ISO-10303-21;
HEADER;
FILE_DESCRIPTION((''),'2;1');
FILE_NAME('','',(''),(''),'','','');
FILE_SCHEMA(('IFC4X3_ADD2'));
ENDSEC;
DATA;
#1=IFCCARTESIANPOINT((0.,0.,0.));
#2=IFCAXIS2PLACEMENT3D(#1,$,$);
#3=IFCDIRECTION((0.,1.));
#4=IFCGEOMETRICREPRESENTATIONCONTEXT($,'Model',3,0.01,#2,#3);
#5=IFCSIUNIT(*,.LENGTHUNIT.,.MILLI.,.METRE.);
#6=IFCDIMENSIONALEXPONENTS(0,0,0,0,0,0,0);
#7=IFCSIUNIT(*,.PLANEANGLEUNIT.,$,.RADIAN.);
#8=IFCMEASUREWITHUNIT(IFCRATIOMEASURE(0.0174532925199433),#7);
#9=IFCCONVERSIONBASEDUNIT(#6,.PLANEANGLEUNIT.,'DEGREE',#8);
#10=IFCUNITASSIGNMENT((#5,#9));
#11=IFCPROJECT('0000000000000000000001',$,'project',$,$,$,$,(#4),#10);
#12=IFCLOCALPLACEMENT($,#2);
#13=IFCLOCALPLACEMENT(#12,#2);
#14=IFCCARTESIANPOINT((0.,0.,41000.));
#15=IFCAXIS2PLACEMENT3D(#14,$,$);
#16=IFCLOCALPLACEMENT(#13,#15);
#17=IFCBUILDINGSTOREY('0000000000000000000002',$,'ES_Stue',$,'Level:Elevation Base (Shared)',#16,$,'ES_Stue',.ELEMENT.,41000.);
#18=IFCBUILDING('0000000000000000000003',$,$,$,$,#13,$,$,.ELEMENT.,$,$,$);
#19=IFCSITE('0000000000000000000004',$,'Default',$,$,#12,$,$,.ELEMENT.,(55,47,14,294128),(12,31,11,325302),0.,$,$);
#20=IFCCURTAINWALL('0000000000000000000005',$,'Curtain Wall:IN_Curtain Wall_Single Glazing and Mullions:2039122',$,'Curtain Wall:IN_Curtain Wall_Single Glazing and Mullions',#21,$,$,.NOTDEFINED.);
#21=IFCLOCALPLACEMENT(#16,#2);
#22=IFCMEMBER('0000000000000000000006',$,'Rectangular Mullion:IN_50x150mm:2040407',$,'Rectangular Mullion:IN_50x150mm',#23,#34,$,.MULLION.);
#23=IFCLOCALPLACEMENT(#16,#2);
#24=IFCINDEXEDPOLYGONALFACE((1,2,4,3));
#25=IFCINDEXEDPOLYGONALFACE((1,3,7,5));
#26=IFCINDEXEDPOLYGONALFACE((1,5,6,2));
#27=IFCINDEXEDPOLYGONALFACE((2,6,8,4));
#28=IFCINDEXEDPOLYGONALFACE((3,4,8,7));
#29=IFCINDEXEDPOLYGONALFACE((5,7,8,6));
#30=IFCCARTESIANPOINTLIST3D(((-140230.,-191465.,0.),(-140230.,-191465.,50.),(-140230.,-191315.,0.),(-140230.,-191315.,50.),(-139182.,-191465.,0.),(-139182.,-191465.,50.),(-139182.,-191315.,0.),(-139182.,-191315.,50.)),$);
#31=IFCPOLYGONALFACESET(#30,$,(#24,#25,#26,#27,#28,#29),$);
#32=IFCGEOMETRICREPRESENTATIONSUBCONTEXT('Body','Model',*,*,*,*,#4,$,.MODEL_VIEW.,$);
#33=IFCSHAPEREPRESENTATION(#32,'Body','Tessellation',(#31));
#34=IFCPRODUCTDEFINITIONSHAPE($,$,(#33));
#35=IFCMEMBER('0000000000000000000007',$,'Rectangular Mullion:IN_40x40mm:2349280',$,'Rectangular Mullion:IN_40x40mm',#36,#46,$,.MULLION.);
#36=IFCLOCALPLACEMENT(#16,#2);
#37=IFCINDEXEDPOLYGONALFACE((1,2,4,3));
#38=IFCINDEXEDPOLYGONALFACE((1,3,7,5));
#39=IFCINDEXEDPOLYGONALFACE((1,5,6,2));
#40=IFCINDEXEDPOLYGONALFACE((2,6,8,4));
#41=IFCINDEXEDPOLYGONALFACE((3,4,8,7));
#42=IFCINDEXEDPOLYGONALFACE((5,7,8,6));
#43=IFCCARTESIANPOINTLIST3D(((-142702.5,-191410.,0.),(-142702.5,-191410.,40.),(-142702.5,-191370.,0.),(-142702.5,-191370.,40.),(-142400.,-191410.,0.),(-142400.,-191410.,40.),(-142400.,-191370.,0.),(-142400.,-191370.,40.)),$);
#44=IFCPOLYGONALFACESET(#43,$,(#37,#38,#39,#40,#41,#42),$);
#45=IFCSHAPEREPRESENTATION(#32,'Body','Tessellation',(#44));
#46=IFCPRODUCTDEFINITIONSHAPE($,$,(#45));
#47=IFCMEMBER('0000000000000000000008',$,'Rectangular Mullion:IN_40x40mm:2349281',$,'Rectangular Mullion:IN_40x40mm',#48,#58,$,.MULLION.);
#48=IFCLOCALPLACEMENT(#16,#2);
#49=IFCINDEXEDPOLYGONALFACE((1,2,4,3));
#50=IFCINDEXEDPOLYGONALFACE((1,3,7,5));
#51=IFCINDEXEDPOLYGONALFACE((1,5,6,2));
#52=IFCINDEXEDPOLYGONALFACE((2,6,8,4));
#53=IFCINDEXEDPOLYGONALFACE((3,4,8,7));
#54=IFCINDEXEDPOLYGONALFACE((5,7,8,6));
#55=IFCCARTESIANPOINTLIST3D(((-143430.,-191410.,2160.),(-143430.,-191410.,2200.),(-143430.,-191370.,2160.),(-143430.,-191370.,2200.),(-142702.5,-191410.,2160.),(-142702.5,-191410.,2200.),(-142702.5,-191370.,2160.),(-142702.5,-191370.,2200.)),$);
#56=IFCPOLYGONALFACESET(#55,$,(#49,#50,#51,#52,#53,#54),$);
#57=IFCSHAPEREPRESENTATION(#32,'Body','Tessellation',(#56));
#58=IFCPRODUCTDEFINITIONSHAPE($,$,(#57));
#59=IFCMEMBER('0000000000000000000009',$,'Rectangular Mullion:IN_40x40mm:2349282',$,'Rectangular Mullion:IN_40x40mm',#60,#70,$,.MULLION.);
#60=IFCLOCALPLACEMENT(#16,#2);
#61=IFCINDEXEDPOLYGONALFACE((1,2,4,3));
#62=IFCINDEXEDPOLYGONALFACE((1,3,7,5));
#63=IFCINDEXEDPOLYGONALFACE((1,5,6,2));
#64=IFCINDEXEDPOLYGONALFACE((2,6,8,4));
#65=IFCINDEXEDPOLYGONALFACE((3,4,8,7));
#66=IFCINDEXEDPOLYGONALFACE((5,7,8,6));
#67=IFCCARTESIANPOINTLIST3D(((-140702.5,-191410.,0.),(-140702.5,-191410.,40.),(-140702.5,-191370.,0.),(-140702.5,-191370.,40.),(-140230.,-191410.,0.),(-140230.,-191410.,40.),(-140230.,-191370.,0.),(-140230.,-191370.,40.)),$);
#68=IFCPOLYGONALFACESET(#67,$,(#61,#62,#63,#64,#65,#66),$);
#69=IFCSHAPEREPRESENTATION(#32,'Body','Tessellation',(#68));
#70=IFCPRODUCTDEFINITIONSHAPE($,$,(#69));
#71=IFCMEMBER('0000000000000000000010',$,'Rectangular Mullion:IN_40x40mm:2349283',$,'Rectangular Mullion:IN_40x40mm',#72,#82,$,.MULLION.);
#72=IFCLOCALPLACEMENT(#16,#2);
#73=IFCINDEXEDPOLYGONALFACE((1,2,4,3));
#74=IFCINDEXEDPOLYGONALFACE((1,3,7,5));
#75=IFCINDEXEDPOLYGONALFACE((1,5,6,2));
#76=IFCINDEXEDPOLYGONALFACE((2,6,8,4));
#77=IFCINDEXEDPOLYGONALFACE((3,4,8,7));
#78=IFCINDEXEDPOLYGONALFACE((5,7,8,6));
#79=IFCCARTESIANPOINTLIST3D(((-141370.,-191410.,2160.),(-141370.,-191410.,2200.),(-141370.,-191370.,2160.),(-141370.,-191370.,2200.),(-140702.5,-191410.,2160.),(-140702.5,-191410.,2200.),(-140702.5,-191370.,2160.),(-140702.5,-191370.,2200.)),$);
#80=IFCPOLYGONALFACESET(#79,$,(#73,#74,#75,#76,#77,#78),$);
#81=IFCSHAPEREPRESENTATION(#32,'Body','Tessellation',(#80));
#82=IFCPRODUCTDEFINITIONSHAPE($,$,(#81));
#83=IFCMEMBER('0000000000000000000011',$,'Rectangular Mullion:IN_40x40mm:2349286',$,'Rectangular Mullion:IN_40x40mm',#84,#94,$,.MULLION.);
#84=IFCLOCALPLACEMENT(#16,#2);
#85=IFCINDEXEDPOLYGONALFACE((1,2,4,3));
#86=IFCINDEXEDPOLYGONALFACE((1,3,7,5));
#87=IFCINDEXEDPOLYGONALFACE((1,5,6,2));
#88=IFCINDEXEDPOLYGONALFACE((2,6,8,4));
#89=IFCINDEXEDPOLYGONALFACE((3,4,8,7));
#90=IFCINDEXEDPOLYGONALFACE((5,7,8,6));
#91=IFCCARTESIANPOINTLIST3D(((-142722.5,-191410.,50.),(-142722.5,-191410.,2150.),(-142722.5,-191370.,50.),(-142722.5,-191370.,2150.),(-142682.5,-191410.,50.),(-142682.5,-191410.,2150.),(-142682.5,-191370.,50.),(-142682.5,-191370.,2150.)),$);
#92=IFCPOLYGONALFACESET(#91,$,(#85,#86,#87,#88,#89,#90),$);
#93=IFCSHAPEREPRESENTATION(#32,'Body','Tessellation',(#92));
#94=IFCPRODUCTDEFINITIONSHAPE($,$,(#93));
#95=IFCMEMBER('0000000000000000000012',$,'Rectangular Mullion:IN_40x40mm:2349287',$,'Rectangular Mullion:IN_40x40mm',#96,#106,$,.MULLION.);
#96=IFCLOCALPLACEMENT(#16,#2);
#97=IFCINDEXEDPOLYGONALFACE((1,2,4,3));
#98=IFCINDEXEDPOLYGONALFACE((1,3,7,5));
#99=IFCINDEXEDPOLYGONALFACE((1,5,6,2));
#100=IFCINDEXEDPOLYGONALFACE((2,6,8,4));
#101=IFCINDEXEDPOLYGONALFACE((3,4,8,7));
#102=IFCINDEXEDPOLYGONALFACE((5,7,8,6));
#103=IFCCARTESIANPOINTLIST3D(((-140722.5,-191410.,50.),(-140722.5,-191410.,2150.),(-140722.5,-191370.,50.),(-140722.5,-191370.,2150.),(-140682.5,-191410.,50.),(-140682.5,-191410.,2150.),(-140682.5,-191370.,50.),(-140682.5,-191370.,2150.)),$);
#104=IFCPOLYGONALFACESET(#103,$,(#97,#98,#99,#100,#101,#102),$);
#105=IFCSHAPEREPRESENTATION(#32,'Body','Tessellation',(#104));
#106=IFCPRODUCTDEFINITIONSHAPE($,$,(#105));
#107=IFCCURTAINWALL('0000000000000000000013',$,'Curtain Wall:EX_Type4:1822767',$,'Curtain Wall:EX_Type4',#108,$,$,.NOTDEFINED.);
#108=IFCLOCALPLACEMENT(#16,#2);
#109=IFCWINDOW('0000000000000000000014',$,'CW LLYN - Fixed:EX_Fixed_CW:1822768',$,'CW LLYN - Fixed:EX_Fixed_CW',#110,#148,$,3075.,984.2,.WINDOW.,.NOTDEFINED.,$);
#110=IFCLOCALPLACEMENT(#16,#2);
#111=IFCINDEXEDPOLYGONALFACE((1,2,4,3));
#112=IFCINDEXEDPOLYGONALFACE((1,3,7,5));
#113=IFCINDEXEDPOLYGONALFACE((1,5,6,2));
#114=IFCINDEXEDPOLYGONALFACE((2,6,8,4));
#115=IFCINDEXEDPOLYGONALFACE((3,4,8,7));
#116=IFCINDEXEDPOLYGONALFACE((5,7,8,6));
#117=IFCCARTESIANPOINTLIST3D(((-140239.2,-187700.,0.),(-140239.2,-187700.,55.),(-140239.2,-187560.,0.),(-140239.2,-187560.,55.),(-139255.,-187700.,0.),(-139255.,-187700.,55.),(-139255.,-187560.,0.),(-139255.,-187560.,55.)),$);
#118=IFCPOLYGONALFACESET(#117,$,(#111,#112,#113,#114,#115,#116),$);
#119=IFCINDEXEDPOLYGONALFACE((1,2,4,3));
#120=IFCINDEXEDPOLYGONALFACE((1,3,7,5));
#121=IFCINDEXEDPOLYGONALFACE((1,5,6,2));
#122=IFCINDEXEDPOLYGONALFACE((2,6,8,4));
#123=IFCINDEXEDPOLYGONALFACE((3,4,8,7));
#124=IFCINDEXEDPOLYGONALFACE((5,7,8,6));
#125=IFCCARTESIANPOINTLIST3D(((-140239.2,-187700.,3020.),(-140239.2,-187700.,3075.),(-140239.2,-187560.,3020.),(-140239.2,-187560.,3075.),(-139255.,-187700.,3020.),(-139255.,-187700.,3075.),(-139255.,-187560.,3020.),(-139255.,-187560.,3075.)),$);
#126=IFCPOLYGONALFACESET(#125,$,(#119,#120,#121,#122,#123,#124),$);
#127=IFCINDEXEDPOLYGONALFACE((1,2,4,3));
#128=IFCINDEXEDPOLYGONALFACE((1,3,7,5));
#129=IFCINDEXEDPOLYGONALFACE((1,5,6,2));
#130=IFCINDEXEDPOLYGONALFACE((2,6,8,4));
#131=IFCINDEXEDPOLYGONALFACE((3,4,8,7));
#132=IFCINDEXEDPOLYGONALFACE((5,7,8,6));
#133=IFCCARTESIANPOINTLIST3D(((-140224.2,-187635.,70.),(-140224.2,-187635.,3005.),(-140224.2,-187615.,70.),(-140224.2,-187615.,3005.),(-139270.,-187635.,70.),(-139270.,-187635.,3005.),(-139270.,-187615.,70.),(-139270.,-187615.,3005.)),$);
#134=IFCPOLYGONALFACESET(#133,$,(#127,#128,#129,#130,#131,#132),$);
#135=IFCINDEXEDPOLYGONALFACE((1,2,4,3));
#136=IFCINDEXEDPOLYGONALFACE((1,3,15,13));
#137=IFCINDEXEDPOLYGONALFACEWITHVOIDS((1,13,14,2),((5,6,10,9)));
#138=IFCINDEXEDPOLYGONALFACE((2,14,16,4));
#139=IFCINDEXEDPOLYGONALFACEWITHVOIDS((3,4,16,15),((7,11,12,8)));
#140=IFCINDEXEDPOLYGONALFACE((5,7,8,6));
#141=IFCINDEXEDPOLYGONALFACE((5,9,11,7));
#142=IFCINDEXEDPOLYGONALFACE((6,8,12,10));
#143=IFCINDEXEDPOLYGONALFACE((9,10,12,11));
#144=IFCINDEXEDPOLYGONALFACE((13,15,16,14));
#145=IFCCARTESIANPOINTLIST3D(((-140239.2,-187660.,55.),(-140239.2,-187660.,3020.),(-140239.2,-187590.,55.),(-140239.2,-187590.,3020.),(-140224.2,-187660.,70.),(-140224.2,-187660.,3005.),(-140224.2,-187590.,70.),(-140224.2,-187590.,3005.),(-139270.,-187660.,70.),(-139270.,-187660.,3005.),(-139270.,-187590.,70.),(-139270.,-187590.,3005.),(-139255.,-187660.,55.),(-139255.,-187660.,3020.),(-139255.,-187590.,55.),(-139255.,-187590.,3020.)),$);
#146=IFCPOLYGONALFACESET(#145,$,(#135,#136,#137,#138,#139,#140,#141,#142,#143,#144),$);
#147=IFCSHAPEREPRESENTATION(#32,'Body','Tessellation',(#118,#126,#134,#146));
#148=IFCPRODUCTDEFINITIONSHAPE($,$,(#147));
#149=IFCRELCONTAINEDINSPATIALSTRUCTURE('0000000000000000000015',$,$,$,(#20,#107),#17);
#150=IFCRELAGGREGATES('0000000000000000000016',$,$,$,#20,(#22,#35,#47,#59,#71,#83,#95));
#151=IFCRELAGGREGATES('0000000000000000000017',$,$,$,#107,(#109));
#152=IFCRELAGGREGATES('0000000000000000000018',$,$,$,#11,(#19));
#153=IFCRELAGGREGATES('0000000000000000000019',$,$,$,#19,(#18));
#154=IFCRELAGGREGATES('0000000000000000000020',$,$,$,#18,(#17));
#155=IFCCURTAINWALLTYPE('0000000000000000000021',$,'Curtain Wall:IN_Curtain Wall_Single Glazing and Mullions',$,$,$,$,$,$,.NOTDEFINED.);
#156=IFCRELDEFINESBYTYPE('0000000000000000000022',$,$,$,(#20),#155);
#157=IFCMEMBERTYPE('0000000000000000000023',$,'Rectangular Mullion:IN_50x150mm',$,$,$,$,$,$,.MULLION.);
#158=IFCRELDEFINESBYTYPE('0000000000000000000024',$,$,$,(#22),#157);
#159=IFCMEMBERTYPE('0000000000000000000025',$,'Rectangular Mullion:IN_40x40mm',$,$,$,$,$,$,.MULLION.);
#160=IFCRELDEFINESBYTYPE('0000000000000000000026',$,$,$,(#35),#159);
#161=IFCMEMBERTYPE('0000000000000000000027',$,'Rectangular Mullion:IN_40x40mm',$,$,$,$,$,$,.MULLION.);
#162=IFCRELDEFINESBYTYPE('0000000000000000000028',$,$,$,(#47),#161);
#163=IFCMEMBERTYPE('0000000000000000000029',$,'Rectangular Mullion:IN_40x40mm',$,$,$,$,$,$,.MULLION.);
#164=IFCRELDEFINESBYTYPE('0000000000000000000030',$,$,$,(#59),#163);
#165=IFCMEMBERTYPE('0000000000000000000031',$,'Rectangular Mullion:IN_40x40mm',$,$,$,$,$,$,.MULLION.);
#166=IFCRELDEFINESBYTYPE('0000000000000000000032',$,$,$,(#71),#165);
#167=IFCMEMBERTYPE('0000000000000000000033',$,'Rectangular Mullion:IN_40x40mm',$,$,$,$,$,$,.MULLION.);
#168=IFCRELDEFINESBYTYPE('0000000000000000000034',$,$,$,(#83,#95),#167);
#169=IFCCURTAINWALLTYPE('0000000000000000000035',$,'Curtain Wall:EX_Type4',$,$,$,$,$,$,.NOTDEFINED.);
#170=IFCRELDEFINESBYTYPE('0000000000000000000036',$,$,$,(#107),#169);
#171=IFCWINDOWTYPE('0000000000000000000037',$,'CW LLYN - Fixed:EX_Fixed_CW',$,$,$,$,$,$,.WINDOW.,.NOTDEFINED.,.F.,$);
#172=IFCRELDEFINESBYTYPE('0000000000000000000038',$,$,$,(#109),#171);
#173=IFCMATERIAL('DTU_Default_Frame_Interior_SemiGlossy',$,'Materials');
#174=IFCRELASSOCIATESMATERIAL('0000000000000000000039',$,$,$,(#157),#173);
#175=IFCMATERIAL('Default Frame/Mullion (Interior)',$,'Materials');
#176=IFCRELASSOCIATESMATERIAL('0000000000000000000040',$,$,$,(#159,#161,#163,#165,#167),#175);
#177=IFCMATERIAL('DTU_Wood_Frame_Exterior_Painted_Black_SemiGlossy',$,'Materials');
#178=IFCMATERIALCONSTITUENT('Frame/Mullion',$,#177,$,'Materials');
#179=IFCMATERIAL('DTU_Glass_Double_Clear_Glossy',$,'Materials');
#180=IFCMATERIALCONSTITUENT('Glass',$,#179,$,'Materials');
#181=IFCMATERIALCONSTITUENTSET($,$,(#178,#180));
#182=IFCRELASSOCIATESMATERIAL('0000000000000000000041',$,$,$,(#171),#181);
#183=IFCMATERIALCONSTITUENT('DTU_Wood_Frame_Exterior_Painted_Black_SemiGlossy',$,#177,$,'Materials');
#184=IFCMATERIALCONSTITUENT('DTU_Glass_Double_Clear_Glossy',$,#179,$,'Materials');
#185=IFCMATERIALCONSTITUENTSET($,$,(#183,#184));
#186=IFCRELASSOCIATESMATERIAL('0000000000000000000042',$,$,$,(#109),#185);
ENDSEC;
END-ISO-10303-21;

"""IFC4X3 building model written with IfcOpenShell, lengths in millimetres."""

from ifc_helpers import new_model, entity, si_unit, converted_unit, direction, frame, frame_2d, origin, origin_2d_with_axis, place, context, subcontext, project, spatial, polyline, rectangle, outline, extrude, source, transform, mapped, material, constituent, constituent_set, material_profile, profile_set, type_object, type_shapes, element, aggregate, save


model = new_model("IFC4X3")

# Units and contexts
model_context = context("Model", 3, precision=0.01, world=origin(), true_north=direction((0.0, 1.0)))
body_context = subcontext(model_context, "Body", "Model", "MODEL_VIEW")
ifc_project = project(units=[si_unit("LENGTHUNIT", "METRE", prefix="MILLI"), converted_unit("PLANEANGLEUNIT", "DEGREE", entity("IfcRatioMeasure", 0.0174532925199433), si_unit("PLANEANGLEUNIT", "RADIAN"), dimensions=[0, 0, 0, 0, 0, 0, 0])], contexts=[model_context])

# Site, building, storey
site_placement = place(None, origin())
site = spatial("IfcSite", under=ifc_project, at=site_placement, Name="Default", CompositionType="ELEMENT", RefLatitude=(55, 47, 14, 294128), RefLongitude=(12, 31, 11, 325302), RefElevation=0.0)
building_placement = place(site_placement, origin())
building = spatial("IfcBuilding", under=site, at=building_placement, CompositionType="ELEMENT")
storey_placement = place(building_placement, frame((0.0, 0.0, 41000.0)))
storey = spatial("IfcBuildingStorey", under=building, at=storey_placement, Name="ES_Stue", ObjectType="Level:Elevation Base (Shared)", LongName="ES_Stue", CompositionType="ELEMENT", Elevation=41000.0)

# Curtain wall, members
curtain_wall_type_1 = type_object("IfcCurtainWallType", Name="Curtain Wall:IN_Curtain Wall_Single Glazing and Mullions", PredefinedType="NOTDEFINED")
curtain_wall_1_placement = place(storey_placement, frame((0.0, 0.0, -41000.0)))
curtain_wall_1 = element("IfcCurtainWall", 1, at=curtain_wall_1_placement, inside=storey, type_object=curtain_wall_type_1, Name="Curtain Wall:IN_Curtain Wall_Single Glazing and Mullions:2039122", ObjectType="Curtain Wall:IN_Curtain Wall_Single Glazing and Mullions", PredefinedType="NOTDEFINED")
ifc_material_1 = material(Name="DTU_Default_Frame_Interior_SemiGlossy", Category="Materials")
ifc_material_profile_1 = material_profile(ifc_material_1, rectangle(XDim=150.0, YDim=50.0, at=origin_2d_with_axis()), Name="IN_50x150mm")
ifc_profile_set_1 = profile_set([ifc_material_profile_1], Name="IN_50x150mm")
member_type_1 = type_object("IfcMemberType", Name="Rectangular Mullion:IN_50x150mm", PredefinedType="MULLION", material=ifc_profile_set_1)
shared_shape_1 = source(origin(), body_context, "Body", "SweptSolid", [
    extrude(rectangle(XDim=150.0, YDim=50.0, at=origin_2d_with_axis()), frame((-25.0, 0.0, -1048.0), z_axis=(0.0, 0.0, 1.0), x_axis=(0.0, -1.0, 0.0)), (0.0, 0.0, 1.0), 1048.0),
])
type_shapes(member_type_1, [shared_shape_1])
member_1_placement = place(curtain_wall_1_placement, frame((-140230.0, -191390.0, 41000.0), z_axis=(-1.0, 0.0, 0.0), x_axis=(0.0, 0.0, -1.0)))
member_1 = element("IfcMember", 2, at=member_1_placement, type_object=member_type_1, Name="Rectangular Mullion:IN_50x150mm:2040407", ObjectType="Rectangular Mullion:IN_50x150mm", PredefinedType="MULLION", context=body_context, shape_type="MappedRepresentation", body=[
    mapped(shared_shape_1, transform((0.0, 0.0, 0.0), scale=1.0)),
])
ifc_material_2 = material(Name="Default Frame/Mullion (Interior)", Category="Materials")
ifc_material_profile_2 = material_profile(ifc_material_2, rectangle(XDim=40.0, YDim=40.0, at=origin_2d_with_axis()), Name="IN_40x40mm")
ifc_profile_set_2 = profile_set([ifc_material_profile_2], Name="IN_40x40mm")
member_type_2 = type_object("IfcMemberType", Name="Rectangular Mullion:IN_40x40mm", PredefinedType="MULLION", material=ifc_profile_set_2)
shared_shape_2 = source(origin(), body_context, "Body", "SweptSolid", [
    extrude(rectangle(XDim=40.0, YDim=40.0, at=origin_2d_with_axis()), frame((-20.0, 0.0, -302.5), z_axis=(0.0, 0.0, 1.0), x_axis=(0.0, -1.0, 0.0)), (0.0, 0.0, 1.0), 302.5),
])
type_shapes(member_type_2, [shared_shape_2])
member_2_placement = place(curtain_wall_1_placement, frame((-142702.5, -191390.0, 41000.0), z_axis=(-1.0, 0.0, 0.0), x_axis=(0.0, 0.0, -1.0)))
member_2 = element("IfcMember", 3, at=member_2_placement, type_object=member_type_2, Name="Rectangular Mullion:IN_40x40mm:2349280", ObjectType="Rectangular Mullion:IN_40x40mm", PredefinedType="MULLION", context=body_context, shape_type="MappedRepresentation", body=[
    mapped(shared_shape_2, transform((0.0, 0.0, 0.0), scale=1.0)),
])
member_type_3 = type_object("IfcMemberType", Name="Rectangular Mullion:IN_40x40mm", PredefinedType="MULLION", material=ifc_profile_set_2)
shared_shape_3 = source(origin(), body_context, "Body", "SweptSolid", [
    extrude(rectangle(XDim=40.0, YDim=40.0, at=origin_2d_with_axis()), frame((-20.0, 0.0, -727.5), z_axis=(0.0, 0.0, 1.0), x_axis=(0.0, -1.0, 0.0)), (0.0, 0.0, 1.0), 727.5),
])
type_shapes(member_type_3, [shared_shape_3])
member_3_placement = place(curtain_wall_1_placement, frame((-142702.5, -191390.0, 43200.0), z_axis=(1.0, 0.0, 0.0), x_axis=(0.0, 0.0, 1.0)))
member_3 = element("IfcMember", 4, at=member_3_placement, type_object=member_type_3, Name="Rectangular Mullion:IN_40x40mm:2349281", ObjectType="Rectangular Mullion:IN_40x40mm", PredefinedType="MULLION", context=body_context, shape_type="MappedRepresentation", body=[
    mapped(shared_shape_3, transform((0.0, 0.0, 0.0), scale=1.0)),
])
member_type_4 = type_object("IfcMemberType", Name="Rectangular Mullion:IN_40x40mm", PredefinedType="MULLION", material=ifc_profile_set_2)
shared_shape_4 = source(origin(), body_context, "Body", "SweptSolid", [
    extrude(rectangle(XDim=40.0, YDim=40.0, at=origin_2d_with_axis()), frame((-20.0, 0.0, -472.5), z_axis=(0.0, 0.0, 1.0), x_axis=(0.0, -1.0, 0.0)), (0.0, 0.0, 1.0), 472.5),
])
type_shapes(member_type_4, [shared_shape_4])
member_4_placement = place(curtain_wall_1_placement, frame((-140702.5, -191390.0, 41000.0), z_axis=(-1.0, 0.0, 0.0), x_axis=(0.0, 0.0, -1.0)))
member_4 = element("IfcMember", 5, at=member_4_placement, type_object=member_type_4, Name="Rectangular Mullion:IN_40x40mm:2349282", ObjectType="Rectangular Mullion:IN_40x40mm", PredefinedType="MULLION", context=body_context, shape_type="MappedRepresentation", body=[
    mapped(shared_shape_4, transform((0.0, 0.0, 0.0), scale=1.0)),
])
member_type_5 = type_object("IfcMemberType", Name="Rectangular Mullion:IN_40x40mm", PredefinedType="MULLION", material=ifc_profile_set_2)
shared_shape_5 = source(origin(), body_context, "Body", "SweptSolid", [
    extrude(rectangle(XDim=40.0, YDim=40.0, at=origin_2d_with_axis()), frame((-20.0, 0.0, -667.5), z_axis=(0.0, 0.0, 1.0), x_axis=(0.0, -1.0, 0.0)), (0.0, 0.0, 1.0), 667.5),
])
type_shapes(member_type_5, [shared_shape_5])
member_5_placement = place(curtain_wall_1_placement, frame((-140702.5, -191390.0, 43200.0), z_axis=(1.0, 0.0, 0.0), x_axis=(0.0, 0.0, 1.0)))
member_5 = element("IfcMember", 6, at=member_5_placement, type_object=member_type_5, Name="Rectangular Mullion:IN_40x40mm:2349283", ObjectType="Rectangular Mullion:IN_40x40mm", PredefinedType="MULLION", context=body_context, shape_type="MappedRepresentation", body=[
    mapped(shared_shape_5, transform((0.0, 0.0, 0.0), scale=1.0)),
])
member_type_6 = type_object("IfcMemberType", Name="Rectangular Mullion:IN_40x40mm", PredefinedType="MULLION", material=ifc_profile_set_2)
shared_shape_6 = source(origin(), body_context, "Body", "SweptSolid", [
    extrude(rectangle(XDim=40.0, YDim=40.0, at=origin_2d_with_axis()), frame((0.0, 0.0, -2100.0), z_axis=(0.0, 0.0, 1.0), x_axis=(0.0, -1.0, 0.0)), (0.0, 0.0, 1.0), 2100.0),
])
type_shapes(member_type_6, [shared_shape_6])
member_6_placement = place(curtain_wall_1_placement, frame((-142702.5, -191390.0, 41050.0), z_axis=(0.0, 0.0, -1.0), x_axis=(1.0, 0.0, 0.0)))
member_6 = element("IfcMember", 7, at=member_6_placement, type_object=member_type_6, Name="Rectangular Mullion:IN_40x40mm:2349286", ObjectType="Rectangular Mullion:IN_40x40mm", PredefinedType="MULLION", context=body_context, shape_type="MappedRepresentation", body=[
    mapped(shared_shape_6, transform((0.0, 0.0, 0.0), scale=1.0)),
])
member_7_placement = place(curtain_wall_1_placement, frame((-140702.5, -191390.0, 41050.0), z_axis=(0.0, 0.0, -1.0), x_axis=(1.0, 0.0, 0.0)))
member_7 = element("IfcMember", 8, at=member_7_placement, type_object=member_type_6, Name="Rectangular Mullion:IN_40x40mm:2349287", ObjectType="Rectangular Mullion:IN_40x40mm", PredefinedType="MULLION", context=body_context, shape_type="MappedRepresentation", body=[
    mapped(shared_shape_6, transform((0.0, 0.0, 0.0), scale=1.0)),
])
aggregate(curtain_wall_1, [member_1, member_2, member_3, member_4, member_5, member_6, member_7])

# Curtain wall, window
curtain_wall_type_2 = type_object("IfcCurtainWallType", Name="Curtain Wall:EX_Type4", PredefinedType="NOTDEFINED")
curtain_wall_2_placement = place(storey_placement, frame((0.0, 0.0, -41000.0)))
curtain_wall_2 = element("IfcCurtainWall", 9, at=curtain_wall_2_placement, inside=storey, type_object=curtain_wall_type_2, Name="Curtain Wall:EX_Type4:1822767", ObjectType="Curtain Wall:EX_Type4", PredefinedType="NOTDEFINED")
ifc_material_3 = material(Name="DTU_Wood_Frame_Exterior_Painted_Black_SemiGlossy", Category="Materials")
ifc_constituent_1 = constituent(ifc_material_3, Name="DTU_Wood_Frame_Exterior_Painted_Black_SemiGlossy", Category="Materials")
ifc_material_4 = material(Name="DTU_Glass_Double_Clear_Glossy", Category="Materials")
ifc_constituent_2 = constituent(ifc_material_4, Name="DTU_Glass_Double_Clear_Glossy", Category="Materials")
ifc_constituent_set_1 = constituent_set(constituents=[ifc_constituent_1, ifc_constituent_2])
ifc_constituent_3 = constituent(ifc_material_3, Name="Frame/Mullion", Category="Materials")
ifc_constituent_4 = constituent(ifc_material_4, Name="Glass", Category="Materials")
ifc_constituent_set_2 = constituent_set(constituents=[ifc_constituent_3, ifc_constituent_4])
window_type_1 = type_object("IfcWindowType", Name="CW LLYN - Fixed:EX_Fixed_CW", ParameterTakesPrecedence=False, PartitioningType="NOTDEFINED", PredefinedType="WINDOW", material=ifc_constituent_set_2)
shared_shape_7 = source(origin(), body_context, "Body", "SweptSolid", [
    extrude(rectangle(XDim=140.0, YDim=984.2, at=frame_2d((0.0, 0.0), x_axis=(1.0, 0.0))), frame((0.0, -130.0, 0.0), z_axis=(0.0, 0.0, 1.0), x_axis=(0.0, -1.0, 0.0)), (0.0, 0.0, 1.0), 55.0),
    extrude(rectangle(XDim=140.0, YDim=984.2, at=frame_2d((0.0, 0.0), x_axis=(1.0, 0.0))), frame((0.0, -130.0, 3020.0), z_axis=(0.0, 0.0, 1.0), x_axis=(0.0, -1.0, 0.0)), (0.0, 0.0, 1.0), 55.0),
    extrude(rectangle(XDim=954.2, YDim=20.0, at=frame_2d((0.0, 0.0), x_axis=(1.0, 0.0))), frame((0.0, -125.0, 70.0), z_axis=(0.0, 0.0, 1.0), x_axis=(-1.0, 0.0, 0.0)), (0.0, 0.0, 1.0), 2935.0),
    extrude(outline(polyline([(-1482.5, -492.1), (1482.5, -492.1), (1482.5, 492.1), (-1482.5, 492.1), (-1482.5, -492.1)]), holes=[polyline([(-1467.5, 477.1), (1467.5, 477.1), (1467.5, -477.1), (-1467.5, -477.1), (-1467.5, 477.1)])]), frame((0.0, -90.0, 1537.5), z_axis=(0.0, -1.0, 0.0), x_axis=(0.0, 0.0, 1.0)), (0.0, 0.0, 1.0), 70.0),
])
type_shapes(window_type_1, [shared_shape_7])
window_1_placement = place(curtain_wall_2_placement, frame((-139747.1, -187500.0, 41000.0)))
window_1 = element("IfcWindow", 10, at=window_1_placement, type_object=window_type_1, material=ifc_constituent_set_1, Name="CW LLYN - Fixed:EX_Fixed_CW:1822768", ObjectType="CW LLYN - Fixed:EX_Fixed_CW", OverallHeight=3075.0, OverallWidth=984.2, PartitioningType="NOTDEFINED", PredefinedType="WINDOW", context=body_context, shape_type="MappedRepresentation", body=[
    mapped(shared_shape_7, transform((0.0, 0.0, 0.0), scale=1.0)),
])
aggregate(curtain_wall_2, [window_1])

save(model, "model.ifc")
